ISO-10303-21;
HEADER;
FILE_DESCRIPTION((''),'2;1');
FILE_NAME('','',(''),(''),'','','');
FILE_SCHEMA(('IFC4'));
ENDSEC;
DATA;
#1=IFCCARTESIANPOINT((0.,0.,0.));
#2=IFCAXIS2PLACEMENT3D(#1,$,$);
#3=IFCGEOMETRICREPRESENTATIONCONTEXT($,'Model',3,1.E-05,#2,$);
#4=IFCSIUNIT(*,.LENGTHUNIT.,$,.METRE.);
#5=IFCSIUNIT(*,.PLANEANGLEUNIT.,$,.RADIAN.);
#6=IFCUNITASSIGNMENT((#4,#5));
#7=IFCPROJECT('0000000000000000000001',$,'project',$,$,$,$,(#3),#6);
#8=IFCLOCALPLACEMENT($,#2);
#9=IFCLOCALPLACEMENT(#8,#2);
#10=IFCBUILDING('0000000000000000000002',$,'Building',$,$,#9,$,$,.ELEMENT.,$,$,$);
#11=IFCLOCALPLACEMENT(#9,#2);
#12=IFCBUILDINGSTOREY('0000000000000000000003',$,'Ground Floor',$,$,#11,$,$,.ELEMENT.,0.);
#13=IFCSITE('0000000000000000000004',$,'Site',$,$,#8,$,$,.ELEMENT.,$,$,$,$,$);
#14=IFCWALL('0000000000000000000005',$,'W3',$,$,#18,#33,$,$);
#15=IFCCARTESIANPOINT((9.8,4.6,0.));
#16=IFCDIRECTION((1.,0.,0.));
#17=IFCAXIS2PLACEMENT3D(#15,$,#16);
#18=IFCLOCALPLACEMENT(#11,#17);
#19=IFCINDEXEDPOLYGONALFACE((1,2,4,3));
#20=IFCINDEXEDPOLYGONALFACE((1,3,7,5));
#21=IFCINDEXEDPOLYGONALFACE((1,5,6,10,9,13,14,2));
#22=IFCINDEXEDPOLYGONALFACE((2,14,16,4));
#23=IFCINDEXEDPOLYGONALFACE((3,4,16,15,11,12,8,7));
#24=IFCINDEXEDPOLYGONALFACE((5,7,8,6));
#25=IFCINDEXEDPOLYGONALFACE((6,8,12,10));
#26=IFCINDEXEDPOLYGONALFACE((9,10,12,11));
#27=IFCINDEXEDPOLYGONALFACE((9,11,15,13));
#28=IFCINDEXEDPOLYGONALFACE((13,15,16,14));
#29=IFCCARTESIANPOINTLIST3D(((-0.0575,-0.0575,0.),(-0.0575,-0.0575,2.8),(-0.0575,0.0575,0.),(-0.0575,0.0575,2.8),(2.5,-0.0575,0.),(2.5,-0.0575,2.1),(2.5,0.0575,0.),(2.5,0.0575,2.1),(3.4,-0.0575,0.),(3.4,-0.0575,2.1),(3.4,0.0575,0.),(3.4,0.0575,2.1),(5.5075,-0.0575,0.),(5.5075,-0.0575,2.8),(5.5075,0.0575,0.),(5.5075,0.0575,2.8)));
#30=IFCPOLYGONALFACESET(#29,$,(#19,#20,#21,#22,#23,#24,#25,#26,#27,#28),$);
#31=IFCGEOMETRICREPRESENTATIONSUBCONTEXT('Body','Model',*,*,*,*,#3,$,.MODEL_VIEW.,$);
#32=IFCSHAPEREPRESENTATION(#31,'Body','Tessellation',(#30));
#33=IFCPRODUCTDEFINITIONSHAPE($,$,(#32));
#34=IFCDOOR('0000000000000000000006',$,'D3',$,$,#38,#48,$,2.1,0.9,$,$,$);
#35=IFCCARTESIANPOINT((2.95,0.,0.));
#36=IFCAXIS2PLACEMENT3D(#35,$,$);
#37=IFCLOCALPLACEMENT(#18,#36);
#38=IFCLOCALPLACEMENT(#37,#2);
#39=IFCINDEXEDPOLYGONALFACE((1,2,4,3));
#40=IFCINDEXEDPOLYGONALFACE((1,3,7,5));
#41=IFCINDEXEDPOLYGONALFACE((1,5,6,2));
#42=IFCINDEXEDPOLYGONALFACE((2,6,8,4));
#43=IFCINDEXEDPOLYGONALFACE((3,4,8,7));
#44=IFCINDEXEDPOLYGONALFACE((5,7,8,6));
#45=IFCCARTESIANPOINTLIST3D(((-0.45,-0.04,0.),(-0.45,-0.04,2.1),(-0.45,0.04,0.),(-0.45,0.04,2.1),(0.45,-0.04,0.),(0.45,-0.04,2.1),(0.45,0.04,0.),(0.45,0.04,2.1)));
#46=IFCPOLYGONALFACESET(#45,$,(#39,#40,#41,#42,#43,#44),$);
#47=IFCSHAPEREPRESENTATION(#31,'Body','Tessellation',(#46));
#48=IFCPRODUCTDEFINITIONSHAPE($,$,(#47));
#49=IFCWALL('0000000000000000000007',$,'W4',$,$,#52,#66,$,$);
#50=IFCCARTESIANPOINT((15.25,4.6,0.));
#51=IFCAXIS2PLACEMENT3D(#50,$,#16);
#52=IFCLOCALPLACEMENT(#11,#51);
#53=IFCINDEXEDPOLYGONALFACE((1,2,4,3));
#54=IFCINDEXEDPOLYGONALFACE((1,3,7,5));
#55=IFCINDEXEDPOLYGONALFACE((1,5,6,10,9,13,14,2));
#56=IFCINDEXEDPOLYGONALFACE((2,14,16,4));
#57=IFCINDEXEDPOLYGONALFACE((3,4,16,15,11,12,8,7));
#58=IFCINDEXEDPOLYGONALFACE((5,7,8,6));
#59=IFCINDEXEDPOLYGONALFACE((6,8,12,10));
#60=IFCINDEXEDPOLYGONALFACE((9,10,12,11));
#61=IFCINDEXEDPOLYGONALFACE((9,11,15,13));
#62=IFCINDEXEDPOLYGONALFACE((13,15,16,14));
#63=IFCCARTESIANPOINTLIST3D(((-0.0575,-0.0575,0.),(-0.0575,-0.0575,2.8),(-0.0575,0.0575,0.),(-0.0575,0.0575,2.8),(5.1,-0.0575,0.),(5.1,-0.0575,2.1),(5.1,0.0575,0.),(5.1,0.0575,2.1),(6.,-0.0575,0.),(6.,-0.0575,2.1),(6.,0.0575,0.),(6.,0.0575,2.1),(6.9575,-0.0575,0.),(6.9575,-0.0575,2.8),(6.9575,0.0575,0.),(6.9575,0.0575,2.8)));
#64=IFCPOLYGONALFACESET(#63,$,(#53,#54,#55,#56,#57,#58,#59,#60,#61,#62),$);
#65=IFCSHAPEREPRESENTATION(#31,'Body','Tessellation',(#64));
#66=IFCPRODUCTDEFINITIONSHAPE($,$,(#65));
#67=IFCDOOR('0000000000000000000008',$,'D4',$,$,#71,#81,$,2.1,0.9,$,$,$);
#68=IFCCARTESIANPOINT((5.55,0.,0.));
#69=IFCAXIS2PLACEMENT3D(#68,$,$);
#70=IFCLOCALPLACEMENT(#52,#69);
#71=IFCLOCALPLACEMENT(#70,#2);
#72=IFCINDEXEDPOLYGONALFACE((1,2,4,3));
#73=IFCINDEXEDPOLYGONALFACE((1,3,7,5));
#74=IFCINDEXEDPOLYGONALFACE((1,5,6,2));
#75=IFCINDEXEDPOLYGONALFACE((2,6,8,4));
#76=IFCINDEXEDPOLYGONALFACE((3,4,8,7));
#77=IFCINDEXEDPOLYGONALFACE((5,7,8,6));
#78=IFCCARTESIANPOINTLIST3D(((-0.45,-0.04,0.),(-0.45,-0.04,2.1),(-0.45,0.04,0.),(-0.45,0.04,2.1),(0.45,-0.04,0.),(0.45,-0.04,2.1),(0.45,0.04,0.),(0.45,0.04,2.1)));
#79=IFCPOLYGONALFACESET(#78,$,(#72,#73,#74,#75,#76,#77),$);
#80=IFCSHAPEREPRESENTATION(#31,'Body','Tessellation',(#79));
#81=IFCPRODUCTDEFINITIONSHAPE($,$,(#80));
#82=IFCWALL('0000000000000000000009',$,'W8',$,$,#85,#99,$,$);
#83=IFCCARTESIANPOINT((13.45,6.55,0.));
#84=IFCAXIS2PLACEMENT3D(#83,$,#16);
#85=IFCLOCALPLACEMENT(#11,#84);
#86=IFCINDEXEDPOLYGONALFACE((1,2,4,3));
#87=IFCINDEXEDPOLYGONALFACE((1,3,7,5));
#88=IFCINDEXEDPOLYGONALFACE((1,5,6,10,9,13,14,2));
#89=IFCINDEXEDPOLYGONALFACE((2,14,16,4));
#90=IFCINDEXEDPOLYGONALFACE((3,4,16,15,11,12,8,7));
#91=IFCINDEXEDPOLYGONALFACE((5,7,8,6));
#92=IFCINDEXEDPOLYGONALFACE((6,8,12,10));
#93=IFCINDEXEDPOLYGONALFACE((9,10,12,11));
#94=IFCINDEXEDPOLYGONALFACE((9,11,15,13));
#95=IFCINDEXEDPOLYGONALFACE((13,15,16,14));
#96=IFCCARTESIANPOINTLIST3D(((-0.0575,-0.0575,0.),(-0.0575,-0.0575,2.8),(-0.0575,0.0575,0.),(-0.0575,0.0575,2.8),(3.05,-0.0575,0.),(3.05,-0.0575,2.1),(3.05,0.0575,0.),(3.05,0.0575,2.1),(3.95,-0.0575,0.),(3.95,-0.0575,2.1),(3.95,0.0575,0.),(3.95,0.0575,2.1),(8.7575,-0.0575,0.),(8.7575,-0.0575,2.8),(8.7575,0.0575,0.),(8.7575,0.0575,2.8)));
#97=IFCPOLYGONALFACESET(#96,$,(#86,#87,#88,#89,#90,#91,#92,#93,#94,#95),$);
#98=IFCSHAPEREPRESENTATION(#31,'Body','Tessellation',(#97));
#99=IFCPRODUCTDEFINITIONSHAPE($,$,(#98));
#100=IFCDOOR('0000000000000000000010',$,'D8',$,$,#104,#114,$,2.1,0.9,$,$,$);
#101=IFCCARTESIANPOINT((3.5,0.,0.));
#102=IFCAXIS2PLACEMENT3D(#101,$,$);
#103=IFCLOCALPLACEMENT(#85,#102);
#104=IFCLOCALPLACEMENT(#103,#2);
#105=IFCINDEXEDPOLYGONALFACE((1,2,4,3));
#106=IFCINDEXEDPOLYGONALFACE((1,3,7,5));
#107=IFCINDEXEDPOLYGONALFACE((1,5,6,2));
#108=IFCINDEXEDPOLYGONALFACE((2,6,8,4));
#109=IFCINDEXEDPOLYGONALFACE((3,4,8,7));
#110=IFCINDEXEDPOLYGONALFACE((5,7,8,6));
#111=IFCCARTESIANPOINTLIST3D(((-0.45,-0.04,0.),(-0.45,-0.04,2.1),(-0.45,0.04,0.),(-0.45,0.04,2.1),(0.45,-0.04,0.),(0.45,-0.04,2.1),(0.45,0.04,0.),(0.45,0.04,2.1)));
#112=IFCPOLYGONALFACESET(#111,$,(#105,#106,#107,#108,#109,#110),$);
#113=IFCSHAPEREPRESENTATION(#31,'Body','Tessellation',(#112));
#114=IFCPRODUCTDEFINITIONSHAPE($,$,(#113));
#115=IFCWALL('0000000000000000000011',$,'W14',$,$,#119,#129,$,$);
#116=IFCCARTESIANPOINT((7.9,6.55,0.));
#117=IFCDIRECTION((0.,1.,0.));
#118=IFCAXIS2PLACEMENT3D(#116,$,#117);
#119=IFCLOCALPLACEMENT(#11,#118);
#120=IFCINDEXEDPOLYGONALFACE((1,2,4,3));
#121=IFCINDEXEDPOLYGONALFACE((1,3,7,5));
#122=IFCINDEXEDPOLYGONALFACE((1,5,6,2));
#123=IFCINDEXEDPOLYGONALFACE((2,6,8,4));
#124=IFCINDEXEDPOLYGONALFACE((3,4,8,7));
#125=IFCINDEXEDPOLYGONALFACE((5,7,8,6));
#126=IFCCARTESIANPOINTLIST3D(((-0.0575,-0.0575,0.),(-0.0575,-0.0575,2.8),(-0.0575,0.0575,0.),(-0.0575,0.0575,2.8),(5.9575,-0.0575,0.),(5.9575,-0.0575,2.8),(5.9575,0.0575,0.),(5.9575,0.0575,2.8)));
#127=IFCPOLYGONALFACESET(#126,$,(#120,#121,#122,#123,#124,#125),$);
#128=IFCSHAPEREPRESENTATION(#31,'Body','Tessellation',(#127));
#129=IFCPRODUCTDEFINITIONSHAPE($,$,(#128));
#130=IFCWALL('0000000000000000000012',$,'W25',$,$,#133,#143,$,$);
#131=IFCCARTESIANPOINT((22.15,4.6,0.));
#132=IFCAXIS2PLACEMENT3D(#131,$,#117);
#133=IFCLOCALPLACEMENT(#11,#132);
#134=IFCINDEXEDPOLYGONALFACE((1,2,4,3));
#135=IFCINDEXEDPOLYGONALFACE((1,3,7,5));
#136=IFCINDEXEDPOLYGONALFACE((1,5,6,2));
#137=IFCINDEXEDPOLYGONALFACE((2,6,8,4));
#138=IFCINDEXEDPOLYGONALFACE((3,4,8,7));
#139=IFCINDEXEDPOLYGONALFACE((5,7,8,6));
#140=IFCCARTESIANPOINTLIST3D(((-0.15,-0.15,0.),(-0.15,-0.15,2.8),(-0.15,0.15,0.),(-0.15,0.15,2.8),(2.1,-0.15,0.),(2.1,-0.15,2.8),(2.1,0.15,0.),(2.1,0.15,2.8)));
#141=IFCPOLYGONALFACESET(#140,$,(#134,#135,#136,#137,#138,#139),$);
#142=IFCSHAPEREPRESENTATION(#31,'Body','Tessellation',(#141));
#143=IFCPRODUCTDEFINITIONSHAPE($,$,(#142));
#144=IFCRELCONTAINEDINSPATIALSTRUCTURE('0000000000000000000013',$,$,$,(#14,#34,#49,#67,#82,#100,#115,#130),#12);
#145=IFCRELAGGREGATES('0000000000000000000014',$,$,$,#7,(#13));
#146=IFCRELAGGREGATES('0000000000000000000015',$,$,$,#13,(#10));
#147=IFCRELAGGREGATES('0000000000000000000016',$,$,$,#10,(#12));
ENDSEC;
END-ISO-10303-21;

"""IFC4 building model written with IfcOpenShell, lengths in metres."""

from ifc_helpers import new_model, si_unit, frame, frame_2d, origin, origin_2d, place, context, subcontext, project, spatial, rectangle, extrude, element, fill, save


model = new_model("IFC4")

# Units and contexts
model_context = context("Model", 3, precision=1e-05, world=origin())
body_context = subcontext(model_context, "Body", "Model", "MODEL_VIEW")
ifc_project = project(units=[si_unit("LENGTHUNIT", "METRE"), si_unit("PLANEANGLEUNIT", "RADIAN")], contexts=[model_context])

# Site, building, storey
site_placement = place(None, origin())
site = spatial("IfcSite", under=ifc_project, at=site_placement, Name="Site", CompositionType="ELEMENT")
building_placement = place(site_placement, origin())
building = spatial("IfcBuilding", under=site, at=building_placement, Name="Building", CompositionType="ELEMENT")
storey_placement = place(building_placement, origin())
storey = spatial("IfcBuildingStorey", under=building, at=storey_placement, Name="Ground Floor", CompositionType="ELEMENT", Elevation=0.0)

# Walls, openings, doors
wall_1_placement = place(storey_placement, frame((9.8, 4.6, 0.0), x_axis=(1.0, 0.0, 0.0)))
wall_1 = element("IfcWall", 1, at=wall_1_placement, inside=storey, Name="W3", context=body_context, shape_type="SweptSolid", body=[
    extrude(rectangle(XDim=5.565, YDim=0.115, at=frame_2d((2.725, 0.0))), origin(), (0.0, 0.0, 1.0), 2.8),
])
opening_1_placement = place(wall_1_placement, frame((2.95, 0.0, 0.0)))
opening_1 = element("IfcOpeningElement", 2, at=opening_1_placement, cuts=wall_1, context=body_context, shape_type="SweptSolid", body=[
    extrude(rectangle(XDim=0.9, YDim=0.215, at=origin_2d()), origin(), (0.0, 0.0, 1.0), 2.1),
])
door_1_placement = place(opening_1_placement, origin())
door_1 = element("IfcDoor", 3, at=door_1_placement, inside=storey, Name="D3", OverallHeight=2.1, OverallWidth=0.9, context=body_context, shape_type="SweptSolid", body=[
    extrude(rectangle(XDim=0.9, YDim=0.08, at=origin_2d()), origin(), (0.0, 0.0, 1.0), 2.1),
])
fill(opening_1, door_1)
wall_2_placement = place(storey_placement, frame((15.25, 4.6, 0.0), x_axis=(1.0, 0.0, 0.0)))
wall_2 = element("IfcWall", 4, at=wall_2_placement, inside=storey, Name="W4", context=body_context, shape_type="SweptSolid", body=[
    extrude(rectangle(XDim=7.015, YDim=0.115, at=frame_2d((3.45, 0.0))), origin(), (0.0, 0.0, 1.0), 2.8),
])
opening_2_placement = place(wall_2_placement, frame((5.55, 0.0, 0.0)))
opening_2 = element("IfcOpeningElement", 5, at=opening_2_placement, cuts=wall_2, context=body_context, shape_type="SweptSolid", body=[
    extrude(rectangle(XDim=0.9, YDim=0.215, at=origin_2d()), origin(), (0.0, 0.0, 1.0), 2.1),
])
door_2_placement = place(opening_2_placement, origin())
door_2 = element("IfcDoor", 6, at=door_2_placement, inside=storey, Name="D4", OverallHeight=2.1, OverallWidth=0.9, context=body_context, shape_type="SweptSolid", body=[
    extrude(rectangle(XDim=0.9, YDim=0.08, at=origin_2d()), origin(), (0.0, 0.0, 1.0), 2.1),
])
fill(opening_2, door_2)
wall_3_placement = place(storey_placement, frame((13.45, 6.55, 0.0), x_axis=(1.0, 0.0, 0.0)))
wall_3 = element("IfcWall", 7, at=wall_3_placement, inside=storey, Name="W8", context=body_context, shape_type="SweptSolid", body=[
    extrude(rectangle(XDim=8.815, YDim=0.115, at=frame_2d((4.35, 0.0))), origin(), (0.0, 0.0, 1.0), 2.8),
])
opening_3_placement = place(wall_3_placement, frame((3.5, 0.0, 0.0)))
opening_3 = element("IfcOpeningElement", 8, at=opening_3_placement, cuts=wall_3, context=body_context, shape_type="SweptSolid", body=[
    extrude(rectangle(XDim=0.9, YDim=0.215, at=origin_2d()), origin(), (0.0, 0.0, 1.0), 2.1),
])
door_3_placement = place(opening_3_placement, origin())
door_3 = element("IfcDoor", 9, at=door_3_placement, inside=storey, Name="D8", OverallHeight=2.1, OverallWidth=0.9, context=body_context, shape_type="SweptSolid", body=[
    extrude(rectangle(XDim=0.9, YDim=0.08, at=origin_2d()), origin(), (0.0, 0.0, 1.0), 2.1),
])
fill(opening_3, door_3)

# Walls
wall_4_placement = place(storey_placement, frame((7.9, 6.55, 0.0), x_axis=(0.0, 1.0, 0.0)))
element("IfcWall", 10, at=wall_4_placement, inside=storey, Name="W14", context=body_context, shape_type="SweptSolid", body=[
    extrude(rectangle(XDim=6.015, YDim=0.115, at=frame_2d((2.95, 0.0))), origin(), (0.0, 0.0, 1.0), 2.8),
])
wall_5_placement = place(storey_placement, frame((22.15, 4.6, 0.0), x_axis=(0.0, 1.0, 0.0)))
element("IfcWall", 11, at=wall_5_placement, inside=storey, Name="W25", context=body_context, shape_type="SweptSolid", body=[
    extrude(rectangle(XDim=2.25, YDim=0.3, at=frame_2d((0.975, 0.0))), origin(), (0.0, 0.0, 1.0), 2.8),
])

save(model, "model.ifc")
